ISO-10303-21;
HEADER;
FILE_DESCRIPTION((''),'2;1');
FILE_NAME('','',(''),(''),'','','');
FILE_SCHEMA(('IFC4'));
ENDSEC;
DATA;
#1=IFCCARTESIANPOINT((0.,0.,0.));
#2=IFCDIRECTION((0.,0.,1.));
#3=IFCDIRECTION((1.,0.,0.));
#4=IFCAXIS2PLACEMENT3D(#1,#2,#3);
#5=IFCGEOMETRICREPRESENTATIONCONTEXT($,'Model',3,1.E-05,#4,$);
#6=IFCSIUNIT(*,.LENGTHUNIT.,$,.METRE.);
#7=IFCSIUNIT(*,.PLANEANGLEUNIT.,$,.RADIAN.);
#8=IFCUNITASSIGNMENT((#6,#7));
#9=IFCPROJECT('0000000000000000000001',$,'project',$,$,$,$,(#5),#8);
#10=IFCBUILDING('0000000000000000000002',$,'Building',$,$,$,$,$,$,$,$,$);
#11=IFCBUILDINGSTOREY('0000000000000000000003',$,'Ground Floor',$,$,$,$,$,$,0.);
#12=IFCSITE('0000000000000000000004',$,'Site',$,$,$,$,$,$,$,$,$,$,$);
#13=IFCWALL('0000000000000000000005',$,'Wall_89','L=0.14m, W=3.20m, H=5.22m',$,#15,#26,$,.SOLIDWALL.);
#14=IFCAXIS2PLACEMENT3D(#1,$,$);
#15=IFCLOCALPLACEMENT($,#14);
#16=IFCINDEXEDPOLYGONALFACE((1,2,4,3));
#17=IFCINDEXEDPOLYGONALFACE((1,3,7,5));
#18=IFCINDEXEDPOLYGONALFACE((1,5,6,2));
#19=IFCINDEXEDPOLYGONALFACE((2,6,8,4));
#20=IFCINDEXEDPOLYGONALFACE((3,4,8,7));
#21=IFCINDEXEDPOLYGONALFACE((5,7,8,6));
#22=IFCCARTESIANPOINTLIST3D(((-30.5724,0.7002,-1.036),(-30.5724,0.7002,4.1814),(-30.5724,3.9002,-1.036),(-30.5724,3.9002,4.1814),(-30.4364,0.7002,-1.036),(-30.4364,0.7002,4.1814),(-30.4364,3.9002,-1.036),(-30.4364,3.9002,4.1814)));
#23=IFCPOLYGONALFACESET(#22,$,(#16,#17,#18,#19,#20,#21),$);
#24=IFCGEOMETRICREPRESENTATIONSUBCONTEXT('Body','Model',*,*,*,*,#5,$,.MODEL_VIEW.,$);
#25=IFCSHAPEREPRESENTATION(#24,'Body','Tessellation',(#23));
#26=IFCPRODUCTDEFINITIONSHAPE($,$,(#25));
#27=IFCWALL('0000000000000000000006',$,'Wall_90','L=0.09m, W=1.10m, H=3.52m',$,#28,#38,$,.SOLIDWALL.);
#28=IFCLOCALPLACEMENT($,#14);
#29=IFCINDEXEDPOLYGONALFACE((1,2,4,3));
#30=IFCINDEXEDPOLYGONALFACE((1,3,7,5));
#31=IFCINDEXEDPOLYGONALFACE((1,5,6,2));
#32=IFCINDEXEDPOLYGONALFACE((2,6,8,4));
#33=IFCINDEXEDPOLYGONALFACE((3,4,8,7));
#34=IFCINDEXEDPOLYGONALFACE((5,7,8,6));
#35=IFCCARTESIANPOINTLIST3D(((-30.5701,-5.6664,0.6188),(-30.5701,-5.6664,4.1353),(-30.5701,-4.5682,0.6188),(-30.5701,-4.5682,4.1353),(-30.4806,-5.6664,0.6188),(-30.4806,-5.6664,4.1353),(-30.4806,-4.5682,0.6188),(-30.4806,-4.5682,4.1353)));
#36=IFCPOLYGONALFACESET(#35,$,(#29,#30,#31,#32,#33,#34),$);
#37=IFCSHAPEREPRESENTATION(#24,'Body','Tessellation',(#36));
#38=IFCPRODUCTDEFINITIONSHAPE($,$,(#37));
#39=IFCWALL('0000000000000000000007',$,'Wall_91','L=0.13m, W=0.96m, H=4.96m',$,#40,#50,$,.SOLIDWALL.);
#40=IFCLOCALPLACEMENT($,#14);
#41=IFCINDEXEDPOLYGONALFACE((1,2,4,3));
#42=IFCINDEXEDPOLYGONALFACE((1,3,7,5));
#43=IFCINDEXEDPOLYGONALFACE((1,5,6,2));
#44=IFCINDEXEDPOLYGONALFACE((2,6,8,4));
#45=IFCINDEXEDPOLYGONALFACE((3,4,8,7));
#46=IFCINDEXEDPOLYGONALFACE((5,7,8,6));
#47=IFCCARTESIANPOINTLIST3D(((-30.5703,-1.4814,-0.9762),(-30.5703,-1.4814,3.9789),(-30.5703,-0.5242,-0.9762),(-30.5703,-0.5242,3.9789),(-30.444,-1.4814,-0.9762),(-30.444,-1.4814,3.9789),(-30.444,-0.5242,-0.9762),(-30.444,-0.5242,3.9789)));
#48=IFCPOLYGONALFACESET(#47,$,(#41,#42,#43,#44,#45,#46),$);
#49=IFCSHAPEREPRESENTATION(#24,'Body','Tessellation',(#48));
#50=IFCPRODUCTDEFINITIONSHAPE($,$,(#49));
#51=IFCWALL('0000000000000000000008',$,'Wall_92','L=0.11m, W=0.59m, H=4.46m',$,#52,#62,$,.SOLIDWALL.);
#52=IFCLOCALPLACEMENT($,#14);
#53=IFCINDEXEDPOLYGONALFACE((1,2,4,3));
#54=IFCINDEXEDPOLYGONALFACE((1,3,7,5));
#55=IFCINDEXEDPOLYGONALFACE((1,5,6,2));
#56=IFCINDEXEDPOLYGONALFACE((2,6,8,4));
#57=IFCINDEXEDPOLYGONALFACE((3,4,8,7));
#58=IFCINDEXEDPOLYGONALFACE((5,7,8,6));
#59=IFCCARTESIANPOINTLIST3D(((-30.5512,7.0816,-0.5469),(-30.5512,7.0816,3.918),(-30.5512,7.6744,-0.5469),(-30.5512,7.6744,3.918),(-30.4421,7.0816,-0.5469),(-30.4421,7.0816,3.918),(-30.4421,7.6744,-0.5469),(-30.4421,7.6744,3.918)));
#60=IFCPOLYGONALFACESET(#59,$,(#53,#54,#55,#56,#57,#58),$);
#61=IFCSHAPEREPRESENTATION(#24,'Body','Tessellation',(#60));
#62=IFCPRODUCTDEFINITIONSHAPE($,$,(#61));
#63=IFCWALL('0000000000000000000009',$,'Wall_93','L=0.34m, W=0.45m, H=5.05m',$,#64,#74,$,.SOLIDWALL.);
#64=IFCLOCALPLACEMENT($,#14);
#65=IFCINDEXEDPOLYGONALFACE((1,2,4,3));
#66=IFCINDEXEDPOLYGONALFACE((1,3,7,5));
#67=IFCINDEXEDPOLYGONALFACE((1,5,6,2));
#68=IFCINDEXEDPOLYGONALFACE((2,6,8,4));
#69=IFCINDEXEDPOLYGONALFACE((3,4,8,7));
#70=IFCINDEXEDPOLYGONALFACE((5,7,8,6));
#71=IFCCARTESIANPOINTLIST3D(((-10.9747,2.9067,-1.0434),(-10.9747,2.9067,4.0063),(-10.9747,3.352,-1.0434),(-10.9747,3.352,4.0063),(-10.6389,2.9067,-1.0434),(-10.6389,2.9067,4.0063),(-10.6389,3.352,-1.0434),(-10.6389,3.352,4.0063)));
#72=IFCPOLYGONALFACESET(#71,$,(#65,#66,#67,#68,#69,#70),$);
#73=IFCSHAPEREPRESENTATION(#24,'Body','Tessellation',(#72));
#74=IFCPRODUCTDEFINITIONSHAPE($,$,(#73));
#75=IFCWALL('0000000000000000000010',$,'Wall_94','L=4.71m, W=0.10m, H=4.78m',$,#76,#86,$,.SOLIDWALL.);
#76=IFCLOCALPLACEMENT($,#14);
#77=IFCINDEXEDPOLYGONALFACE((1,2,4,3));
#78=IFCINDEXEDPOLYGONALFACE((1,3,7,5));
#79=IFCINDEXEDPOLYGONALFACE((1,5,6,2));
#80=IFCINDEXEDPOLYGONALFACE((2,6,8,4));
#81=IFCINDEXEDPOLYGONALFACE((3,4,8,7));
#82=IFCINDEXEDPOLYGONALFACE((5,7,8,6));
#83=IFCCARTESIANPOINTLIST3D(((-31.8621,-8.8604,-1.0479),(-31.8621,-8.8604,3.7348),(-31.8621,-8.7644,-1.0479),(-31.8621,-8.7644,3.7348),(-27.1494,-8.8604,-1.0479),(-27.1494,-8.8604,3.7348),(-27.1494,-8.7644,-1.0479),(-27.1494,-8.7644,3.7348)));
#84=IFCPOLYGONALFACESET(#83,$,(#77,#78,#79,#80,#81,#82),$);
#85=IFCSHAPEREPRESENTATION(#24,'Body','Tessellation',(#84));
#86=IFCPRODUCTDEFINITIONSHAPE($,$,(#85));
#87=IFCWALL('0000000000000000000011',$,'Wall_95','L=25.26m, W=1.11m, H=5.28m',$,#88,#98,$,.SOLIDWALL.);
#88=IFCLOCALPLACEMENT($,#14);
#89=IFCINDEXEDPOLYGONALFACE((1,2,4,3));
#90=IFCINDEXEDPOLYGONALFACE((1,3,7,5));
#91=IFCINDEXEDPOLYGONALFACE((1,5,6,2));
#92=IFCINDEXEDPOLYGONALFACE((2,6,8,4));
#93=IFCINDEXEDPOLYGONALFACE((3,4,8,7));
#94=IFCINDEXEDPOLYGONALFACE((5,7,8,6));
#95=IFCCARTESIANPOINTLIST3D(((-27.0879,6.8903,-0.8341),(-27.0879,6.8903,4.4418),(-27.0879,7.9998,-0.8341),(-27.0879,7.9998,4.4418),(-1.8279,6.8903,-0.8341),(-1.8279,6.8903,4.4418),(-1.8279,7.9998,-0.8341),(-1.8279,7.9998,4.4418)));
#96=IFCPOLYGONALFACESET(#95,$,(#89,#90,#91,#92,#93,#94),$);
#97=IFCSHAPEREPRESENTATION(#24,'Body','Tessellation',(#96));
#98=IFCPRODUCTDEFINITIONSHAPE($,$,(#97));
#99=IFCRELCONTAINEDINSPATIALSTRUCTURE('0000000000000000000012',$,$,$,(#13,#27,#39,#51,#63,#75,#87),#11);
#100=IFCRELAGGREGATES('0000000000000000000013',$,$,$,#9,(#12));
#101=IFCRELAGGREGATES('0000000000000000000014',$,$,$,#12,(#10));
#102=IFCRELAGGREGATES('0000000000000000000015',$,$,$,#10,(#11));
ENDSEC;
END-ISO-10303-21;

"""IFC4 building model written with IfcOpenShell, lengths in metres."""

from ifc_helpers import new_model, si_unit, frame, origin_with_axes, origin_2d, context, subcontext, project, spatial, rectangle, extrude, element, save


model = new_model("IFC4")

# Units and contexts
model_context = context("Model", 3, precision=1e-05, world=origin_with_axes())
body_context = subcontext(model_context, "Body", "Model", "MODEL_VIEW")
ifc_project = project(units=[si_unit("LENGTHUNIT", "METRE"), si_unit("PLANEANGLEUNIT", "RADIAN")], contexts=[model_context])

# Site, building, storey
site = spatial("IfcSite", under=ifc_project, Name="Site")
building = spatial("IfcBuilding", under=site, Name="Building")
storey = spatial("IfcBuildingStorey", under=building, Name="Ground Floor", Elevation=0.0)

# Walls
element("IfcWall", 1, inside=storey, Name="Wall_89", Description="L=0.14m, W=3.20m, H=5.22m", PredefinedType="SOLIDWALL", context=body_context, shape_type="SweptSolid", body=[
    extrude(rectangle(XDim=0.136, YDim=3.2, at=origin_2d()), frame((-30.5044, 2.3002, -1.036), z_axis=(0.0, 0.0, 1.0), x_axis=(1.0, 0.0, 0.0)), (0.0, 0.0, 1.0), 5.2174),
])
element("IfcWall", 2, inside=storey, Name="Wall_90", Description="L=0.09m, W=1.10m, H=3.52m", PredefinedType="SOLIDWALL", context=body_context, shape_type="SweptSolid", body=[
    extrude(rectangle(XDim=0.0895, YDim=1.0983, at=origin_2d()), frame((-30.5254, -5.1173, 0.6188), z_axis=(0.0, 0.0, 1.0), x_axis=(1.0, 0.0, 0.0)), (0.0, 0.0, 1.0), 3.5166),
])
element("IfcWall", 3, inside=storey, Name="Wall_91", Description="L=0.13m, W=0.96m, H=4.96m", PredefinedType="SOLIDWALL", context=body_context, shape_type="SweptSolid", body=[
    extrude(rectangle(XDim=0.1263, YDim=0.9571, at=origin_2d()), frame((-30.5071, -1.0028, -0.9762), z_axis=(0.0, 0.0, 1.0), x_axis=(1.0, 0.0, 0.0)), (0.0, 0.0, 1.0), 4.9551),
])
element("IfcWall", 4, inside=storey, Name="Wall_92", Description="L=0.11m, W=0.59m, H=4.46m", PredefinedType="SOLIDWALL", context=body_context, shape_type="SweptSolid", body=[
    extrude(rectangle(XDim=0.1091, YDim=0.5928, at=origin_2d()), frame((-30.4967, 7.378, -0.5469), z_axis=(0.0, 0.0, 1.0), x_axis=(1.0, 0.0, 0.0)), (0.0, 0.0, 1.0), 4.4649),
])
element("IfcWall", 5, inside=storey, Name="Wall_93", Description="L=0.34m, W=0.45m, H=5.05m", PredefinedType="SOLIDWALL", context=body_context, shape_type="SweptSolid", body=[
    extrude(rectangle(XDim=0.3358, YDim=0.4454, at=origin_2d()), frame((-10.8068, 3.1293, -1.0434), z_axis=(0.0, 0.0, 1.0), x_axis=(1.0, 0.0, 0.0)), (0.0, 0.0, 1.0), 5.0497),
])
element("IfcWall", 6, inside=storey, Name="Wall_94", Description="L=4.71m, W=0.10m, H=4.78m", PredefinedType="SOLIDWALL", context=body_context, shape_type="SweptSolid", body=[
    extrude(rectangle(XDim=4.7127, YDim=0.0959, at=origin_2d()), frame((-29.5058, -8.8124, -1.0479), z_axis=(0.0, 0.0, 1.0), x_axis=(1.0, 0.0, 0.0)), (0.0, 0.0, 1.0), 4.7827),
])
element("IfcWall", 7, inside=storey, Name="Wall_95", Description="L=25.26m, W=1.11m, H=5.28m", PredefinedType="SOLIDWALL", context=body_context, shape_type="SweptSolid", body=[
    extrude(rectangle(XDim=25.26, YDim=1.1095, at=origin_2d()), frame((-14.4579, 7.4451, -0.8341), z_axis=(0.0, 0.0, 1.0), x_axis=(1.0, 0.0, 0.0)), (0.0, 0.0, 1.0), 5.276),
])

save(model, "model.ifc")
